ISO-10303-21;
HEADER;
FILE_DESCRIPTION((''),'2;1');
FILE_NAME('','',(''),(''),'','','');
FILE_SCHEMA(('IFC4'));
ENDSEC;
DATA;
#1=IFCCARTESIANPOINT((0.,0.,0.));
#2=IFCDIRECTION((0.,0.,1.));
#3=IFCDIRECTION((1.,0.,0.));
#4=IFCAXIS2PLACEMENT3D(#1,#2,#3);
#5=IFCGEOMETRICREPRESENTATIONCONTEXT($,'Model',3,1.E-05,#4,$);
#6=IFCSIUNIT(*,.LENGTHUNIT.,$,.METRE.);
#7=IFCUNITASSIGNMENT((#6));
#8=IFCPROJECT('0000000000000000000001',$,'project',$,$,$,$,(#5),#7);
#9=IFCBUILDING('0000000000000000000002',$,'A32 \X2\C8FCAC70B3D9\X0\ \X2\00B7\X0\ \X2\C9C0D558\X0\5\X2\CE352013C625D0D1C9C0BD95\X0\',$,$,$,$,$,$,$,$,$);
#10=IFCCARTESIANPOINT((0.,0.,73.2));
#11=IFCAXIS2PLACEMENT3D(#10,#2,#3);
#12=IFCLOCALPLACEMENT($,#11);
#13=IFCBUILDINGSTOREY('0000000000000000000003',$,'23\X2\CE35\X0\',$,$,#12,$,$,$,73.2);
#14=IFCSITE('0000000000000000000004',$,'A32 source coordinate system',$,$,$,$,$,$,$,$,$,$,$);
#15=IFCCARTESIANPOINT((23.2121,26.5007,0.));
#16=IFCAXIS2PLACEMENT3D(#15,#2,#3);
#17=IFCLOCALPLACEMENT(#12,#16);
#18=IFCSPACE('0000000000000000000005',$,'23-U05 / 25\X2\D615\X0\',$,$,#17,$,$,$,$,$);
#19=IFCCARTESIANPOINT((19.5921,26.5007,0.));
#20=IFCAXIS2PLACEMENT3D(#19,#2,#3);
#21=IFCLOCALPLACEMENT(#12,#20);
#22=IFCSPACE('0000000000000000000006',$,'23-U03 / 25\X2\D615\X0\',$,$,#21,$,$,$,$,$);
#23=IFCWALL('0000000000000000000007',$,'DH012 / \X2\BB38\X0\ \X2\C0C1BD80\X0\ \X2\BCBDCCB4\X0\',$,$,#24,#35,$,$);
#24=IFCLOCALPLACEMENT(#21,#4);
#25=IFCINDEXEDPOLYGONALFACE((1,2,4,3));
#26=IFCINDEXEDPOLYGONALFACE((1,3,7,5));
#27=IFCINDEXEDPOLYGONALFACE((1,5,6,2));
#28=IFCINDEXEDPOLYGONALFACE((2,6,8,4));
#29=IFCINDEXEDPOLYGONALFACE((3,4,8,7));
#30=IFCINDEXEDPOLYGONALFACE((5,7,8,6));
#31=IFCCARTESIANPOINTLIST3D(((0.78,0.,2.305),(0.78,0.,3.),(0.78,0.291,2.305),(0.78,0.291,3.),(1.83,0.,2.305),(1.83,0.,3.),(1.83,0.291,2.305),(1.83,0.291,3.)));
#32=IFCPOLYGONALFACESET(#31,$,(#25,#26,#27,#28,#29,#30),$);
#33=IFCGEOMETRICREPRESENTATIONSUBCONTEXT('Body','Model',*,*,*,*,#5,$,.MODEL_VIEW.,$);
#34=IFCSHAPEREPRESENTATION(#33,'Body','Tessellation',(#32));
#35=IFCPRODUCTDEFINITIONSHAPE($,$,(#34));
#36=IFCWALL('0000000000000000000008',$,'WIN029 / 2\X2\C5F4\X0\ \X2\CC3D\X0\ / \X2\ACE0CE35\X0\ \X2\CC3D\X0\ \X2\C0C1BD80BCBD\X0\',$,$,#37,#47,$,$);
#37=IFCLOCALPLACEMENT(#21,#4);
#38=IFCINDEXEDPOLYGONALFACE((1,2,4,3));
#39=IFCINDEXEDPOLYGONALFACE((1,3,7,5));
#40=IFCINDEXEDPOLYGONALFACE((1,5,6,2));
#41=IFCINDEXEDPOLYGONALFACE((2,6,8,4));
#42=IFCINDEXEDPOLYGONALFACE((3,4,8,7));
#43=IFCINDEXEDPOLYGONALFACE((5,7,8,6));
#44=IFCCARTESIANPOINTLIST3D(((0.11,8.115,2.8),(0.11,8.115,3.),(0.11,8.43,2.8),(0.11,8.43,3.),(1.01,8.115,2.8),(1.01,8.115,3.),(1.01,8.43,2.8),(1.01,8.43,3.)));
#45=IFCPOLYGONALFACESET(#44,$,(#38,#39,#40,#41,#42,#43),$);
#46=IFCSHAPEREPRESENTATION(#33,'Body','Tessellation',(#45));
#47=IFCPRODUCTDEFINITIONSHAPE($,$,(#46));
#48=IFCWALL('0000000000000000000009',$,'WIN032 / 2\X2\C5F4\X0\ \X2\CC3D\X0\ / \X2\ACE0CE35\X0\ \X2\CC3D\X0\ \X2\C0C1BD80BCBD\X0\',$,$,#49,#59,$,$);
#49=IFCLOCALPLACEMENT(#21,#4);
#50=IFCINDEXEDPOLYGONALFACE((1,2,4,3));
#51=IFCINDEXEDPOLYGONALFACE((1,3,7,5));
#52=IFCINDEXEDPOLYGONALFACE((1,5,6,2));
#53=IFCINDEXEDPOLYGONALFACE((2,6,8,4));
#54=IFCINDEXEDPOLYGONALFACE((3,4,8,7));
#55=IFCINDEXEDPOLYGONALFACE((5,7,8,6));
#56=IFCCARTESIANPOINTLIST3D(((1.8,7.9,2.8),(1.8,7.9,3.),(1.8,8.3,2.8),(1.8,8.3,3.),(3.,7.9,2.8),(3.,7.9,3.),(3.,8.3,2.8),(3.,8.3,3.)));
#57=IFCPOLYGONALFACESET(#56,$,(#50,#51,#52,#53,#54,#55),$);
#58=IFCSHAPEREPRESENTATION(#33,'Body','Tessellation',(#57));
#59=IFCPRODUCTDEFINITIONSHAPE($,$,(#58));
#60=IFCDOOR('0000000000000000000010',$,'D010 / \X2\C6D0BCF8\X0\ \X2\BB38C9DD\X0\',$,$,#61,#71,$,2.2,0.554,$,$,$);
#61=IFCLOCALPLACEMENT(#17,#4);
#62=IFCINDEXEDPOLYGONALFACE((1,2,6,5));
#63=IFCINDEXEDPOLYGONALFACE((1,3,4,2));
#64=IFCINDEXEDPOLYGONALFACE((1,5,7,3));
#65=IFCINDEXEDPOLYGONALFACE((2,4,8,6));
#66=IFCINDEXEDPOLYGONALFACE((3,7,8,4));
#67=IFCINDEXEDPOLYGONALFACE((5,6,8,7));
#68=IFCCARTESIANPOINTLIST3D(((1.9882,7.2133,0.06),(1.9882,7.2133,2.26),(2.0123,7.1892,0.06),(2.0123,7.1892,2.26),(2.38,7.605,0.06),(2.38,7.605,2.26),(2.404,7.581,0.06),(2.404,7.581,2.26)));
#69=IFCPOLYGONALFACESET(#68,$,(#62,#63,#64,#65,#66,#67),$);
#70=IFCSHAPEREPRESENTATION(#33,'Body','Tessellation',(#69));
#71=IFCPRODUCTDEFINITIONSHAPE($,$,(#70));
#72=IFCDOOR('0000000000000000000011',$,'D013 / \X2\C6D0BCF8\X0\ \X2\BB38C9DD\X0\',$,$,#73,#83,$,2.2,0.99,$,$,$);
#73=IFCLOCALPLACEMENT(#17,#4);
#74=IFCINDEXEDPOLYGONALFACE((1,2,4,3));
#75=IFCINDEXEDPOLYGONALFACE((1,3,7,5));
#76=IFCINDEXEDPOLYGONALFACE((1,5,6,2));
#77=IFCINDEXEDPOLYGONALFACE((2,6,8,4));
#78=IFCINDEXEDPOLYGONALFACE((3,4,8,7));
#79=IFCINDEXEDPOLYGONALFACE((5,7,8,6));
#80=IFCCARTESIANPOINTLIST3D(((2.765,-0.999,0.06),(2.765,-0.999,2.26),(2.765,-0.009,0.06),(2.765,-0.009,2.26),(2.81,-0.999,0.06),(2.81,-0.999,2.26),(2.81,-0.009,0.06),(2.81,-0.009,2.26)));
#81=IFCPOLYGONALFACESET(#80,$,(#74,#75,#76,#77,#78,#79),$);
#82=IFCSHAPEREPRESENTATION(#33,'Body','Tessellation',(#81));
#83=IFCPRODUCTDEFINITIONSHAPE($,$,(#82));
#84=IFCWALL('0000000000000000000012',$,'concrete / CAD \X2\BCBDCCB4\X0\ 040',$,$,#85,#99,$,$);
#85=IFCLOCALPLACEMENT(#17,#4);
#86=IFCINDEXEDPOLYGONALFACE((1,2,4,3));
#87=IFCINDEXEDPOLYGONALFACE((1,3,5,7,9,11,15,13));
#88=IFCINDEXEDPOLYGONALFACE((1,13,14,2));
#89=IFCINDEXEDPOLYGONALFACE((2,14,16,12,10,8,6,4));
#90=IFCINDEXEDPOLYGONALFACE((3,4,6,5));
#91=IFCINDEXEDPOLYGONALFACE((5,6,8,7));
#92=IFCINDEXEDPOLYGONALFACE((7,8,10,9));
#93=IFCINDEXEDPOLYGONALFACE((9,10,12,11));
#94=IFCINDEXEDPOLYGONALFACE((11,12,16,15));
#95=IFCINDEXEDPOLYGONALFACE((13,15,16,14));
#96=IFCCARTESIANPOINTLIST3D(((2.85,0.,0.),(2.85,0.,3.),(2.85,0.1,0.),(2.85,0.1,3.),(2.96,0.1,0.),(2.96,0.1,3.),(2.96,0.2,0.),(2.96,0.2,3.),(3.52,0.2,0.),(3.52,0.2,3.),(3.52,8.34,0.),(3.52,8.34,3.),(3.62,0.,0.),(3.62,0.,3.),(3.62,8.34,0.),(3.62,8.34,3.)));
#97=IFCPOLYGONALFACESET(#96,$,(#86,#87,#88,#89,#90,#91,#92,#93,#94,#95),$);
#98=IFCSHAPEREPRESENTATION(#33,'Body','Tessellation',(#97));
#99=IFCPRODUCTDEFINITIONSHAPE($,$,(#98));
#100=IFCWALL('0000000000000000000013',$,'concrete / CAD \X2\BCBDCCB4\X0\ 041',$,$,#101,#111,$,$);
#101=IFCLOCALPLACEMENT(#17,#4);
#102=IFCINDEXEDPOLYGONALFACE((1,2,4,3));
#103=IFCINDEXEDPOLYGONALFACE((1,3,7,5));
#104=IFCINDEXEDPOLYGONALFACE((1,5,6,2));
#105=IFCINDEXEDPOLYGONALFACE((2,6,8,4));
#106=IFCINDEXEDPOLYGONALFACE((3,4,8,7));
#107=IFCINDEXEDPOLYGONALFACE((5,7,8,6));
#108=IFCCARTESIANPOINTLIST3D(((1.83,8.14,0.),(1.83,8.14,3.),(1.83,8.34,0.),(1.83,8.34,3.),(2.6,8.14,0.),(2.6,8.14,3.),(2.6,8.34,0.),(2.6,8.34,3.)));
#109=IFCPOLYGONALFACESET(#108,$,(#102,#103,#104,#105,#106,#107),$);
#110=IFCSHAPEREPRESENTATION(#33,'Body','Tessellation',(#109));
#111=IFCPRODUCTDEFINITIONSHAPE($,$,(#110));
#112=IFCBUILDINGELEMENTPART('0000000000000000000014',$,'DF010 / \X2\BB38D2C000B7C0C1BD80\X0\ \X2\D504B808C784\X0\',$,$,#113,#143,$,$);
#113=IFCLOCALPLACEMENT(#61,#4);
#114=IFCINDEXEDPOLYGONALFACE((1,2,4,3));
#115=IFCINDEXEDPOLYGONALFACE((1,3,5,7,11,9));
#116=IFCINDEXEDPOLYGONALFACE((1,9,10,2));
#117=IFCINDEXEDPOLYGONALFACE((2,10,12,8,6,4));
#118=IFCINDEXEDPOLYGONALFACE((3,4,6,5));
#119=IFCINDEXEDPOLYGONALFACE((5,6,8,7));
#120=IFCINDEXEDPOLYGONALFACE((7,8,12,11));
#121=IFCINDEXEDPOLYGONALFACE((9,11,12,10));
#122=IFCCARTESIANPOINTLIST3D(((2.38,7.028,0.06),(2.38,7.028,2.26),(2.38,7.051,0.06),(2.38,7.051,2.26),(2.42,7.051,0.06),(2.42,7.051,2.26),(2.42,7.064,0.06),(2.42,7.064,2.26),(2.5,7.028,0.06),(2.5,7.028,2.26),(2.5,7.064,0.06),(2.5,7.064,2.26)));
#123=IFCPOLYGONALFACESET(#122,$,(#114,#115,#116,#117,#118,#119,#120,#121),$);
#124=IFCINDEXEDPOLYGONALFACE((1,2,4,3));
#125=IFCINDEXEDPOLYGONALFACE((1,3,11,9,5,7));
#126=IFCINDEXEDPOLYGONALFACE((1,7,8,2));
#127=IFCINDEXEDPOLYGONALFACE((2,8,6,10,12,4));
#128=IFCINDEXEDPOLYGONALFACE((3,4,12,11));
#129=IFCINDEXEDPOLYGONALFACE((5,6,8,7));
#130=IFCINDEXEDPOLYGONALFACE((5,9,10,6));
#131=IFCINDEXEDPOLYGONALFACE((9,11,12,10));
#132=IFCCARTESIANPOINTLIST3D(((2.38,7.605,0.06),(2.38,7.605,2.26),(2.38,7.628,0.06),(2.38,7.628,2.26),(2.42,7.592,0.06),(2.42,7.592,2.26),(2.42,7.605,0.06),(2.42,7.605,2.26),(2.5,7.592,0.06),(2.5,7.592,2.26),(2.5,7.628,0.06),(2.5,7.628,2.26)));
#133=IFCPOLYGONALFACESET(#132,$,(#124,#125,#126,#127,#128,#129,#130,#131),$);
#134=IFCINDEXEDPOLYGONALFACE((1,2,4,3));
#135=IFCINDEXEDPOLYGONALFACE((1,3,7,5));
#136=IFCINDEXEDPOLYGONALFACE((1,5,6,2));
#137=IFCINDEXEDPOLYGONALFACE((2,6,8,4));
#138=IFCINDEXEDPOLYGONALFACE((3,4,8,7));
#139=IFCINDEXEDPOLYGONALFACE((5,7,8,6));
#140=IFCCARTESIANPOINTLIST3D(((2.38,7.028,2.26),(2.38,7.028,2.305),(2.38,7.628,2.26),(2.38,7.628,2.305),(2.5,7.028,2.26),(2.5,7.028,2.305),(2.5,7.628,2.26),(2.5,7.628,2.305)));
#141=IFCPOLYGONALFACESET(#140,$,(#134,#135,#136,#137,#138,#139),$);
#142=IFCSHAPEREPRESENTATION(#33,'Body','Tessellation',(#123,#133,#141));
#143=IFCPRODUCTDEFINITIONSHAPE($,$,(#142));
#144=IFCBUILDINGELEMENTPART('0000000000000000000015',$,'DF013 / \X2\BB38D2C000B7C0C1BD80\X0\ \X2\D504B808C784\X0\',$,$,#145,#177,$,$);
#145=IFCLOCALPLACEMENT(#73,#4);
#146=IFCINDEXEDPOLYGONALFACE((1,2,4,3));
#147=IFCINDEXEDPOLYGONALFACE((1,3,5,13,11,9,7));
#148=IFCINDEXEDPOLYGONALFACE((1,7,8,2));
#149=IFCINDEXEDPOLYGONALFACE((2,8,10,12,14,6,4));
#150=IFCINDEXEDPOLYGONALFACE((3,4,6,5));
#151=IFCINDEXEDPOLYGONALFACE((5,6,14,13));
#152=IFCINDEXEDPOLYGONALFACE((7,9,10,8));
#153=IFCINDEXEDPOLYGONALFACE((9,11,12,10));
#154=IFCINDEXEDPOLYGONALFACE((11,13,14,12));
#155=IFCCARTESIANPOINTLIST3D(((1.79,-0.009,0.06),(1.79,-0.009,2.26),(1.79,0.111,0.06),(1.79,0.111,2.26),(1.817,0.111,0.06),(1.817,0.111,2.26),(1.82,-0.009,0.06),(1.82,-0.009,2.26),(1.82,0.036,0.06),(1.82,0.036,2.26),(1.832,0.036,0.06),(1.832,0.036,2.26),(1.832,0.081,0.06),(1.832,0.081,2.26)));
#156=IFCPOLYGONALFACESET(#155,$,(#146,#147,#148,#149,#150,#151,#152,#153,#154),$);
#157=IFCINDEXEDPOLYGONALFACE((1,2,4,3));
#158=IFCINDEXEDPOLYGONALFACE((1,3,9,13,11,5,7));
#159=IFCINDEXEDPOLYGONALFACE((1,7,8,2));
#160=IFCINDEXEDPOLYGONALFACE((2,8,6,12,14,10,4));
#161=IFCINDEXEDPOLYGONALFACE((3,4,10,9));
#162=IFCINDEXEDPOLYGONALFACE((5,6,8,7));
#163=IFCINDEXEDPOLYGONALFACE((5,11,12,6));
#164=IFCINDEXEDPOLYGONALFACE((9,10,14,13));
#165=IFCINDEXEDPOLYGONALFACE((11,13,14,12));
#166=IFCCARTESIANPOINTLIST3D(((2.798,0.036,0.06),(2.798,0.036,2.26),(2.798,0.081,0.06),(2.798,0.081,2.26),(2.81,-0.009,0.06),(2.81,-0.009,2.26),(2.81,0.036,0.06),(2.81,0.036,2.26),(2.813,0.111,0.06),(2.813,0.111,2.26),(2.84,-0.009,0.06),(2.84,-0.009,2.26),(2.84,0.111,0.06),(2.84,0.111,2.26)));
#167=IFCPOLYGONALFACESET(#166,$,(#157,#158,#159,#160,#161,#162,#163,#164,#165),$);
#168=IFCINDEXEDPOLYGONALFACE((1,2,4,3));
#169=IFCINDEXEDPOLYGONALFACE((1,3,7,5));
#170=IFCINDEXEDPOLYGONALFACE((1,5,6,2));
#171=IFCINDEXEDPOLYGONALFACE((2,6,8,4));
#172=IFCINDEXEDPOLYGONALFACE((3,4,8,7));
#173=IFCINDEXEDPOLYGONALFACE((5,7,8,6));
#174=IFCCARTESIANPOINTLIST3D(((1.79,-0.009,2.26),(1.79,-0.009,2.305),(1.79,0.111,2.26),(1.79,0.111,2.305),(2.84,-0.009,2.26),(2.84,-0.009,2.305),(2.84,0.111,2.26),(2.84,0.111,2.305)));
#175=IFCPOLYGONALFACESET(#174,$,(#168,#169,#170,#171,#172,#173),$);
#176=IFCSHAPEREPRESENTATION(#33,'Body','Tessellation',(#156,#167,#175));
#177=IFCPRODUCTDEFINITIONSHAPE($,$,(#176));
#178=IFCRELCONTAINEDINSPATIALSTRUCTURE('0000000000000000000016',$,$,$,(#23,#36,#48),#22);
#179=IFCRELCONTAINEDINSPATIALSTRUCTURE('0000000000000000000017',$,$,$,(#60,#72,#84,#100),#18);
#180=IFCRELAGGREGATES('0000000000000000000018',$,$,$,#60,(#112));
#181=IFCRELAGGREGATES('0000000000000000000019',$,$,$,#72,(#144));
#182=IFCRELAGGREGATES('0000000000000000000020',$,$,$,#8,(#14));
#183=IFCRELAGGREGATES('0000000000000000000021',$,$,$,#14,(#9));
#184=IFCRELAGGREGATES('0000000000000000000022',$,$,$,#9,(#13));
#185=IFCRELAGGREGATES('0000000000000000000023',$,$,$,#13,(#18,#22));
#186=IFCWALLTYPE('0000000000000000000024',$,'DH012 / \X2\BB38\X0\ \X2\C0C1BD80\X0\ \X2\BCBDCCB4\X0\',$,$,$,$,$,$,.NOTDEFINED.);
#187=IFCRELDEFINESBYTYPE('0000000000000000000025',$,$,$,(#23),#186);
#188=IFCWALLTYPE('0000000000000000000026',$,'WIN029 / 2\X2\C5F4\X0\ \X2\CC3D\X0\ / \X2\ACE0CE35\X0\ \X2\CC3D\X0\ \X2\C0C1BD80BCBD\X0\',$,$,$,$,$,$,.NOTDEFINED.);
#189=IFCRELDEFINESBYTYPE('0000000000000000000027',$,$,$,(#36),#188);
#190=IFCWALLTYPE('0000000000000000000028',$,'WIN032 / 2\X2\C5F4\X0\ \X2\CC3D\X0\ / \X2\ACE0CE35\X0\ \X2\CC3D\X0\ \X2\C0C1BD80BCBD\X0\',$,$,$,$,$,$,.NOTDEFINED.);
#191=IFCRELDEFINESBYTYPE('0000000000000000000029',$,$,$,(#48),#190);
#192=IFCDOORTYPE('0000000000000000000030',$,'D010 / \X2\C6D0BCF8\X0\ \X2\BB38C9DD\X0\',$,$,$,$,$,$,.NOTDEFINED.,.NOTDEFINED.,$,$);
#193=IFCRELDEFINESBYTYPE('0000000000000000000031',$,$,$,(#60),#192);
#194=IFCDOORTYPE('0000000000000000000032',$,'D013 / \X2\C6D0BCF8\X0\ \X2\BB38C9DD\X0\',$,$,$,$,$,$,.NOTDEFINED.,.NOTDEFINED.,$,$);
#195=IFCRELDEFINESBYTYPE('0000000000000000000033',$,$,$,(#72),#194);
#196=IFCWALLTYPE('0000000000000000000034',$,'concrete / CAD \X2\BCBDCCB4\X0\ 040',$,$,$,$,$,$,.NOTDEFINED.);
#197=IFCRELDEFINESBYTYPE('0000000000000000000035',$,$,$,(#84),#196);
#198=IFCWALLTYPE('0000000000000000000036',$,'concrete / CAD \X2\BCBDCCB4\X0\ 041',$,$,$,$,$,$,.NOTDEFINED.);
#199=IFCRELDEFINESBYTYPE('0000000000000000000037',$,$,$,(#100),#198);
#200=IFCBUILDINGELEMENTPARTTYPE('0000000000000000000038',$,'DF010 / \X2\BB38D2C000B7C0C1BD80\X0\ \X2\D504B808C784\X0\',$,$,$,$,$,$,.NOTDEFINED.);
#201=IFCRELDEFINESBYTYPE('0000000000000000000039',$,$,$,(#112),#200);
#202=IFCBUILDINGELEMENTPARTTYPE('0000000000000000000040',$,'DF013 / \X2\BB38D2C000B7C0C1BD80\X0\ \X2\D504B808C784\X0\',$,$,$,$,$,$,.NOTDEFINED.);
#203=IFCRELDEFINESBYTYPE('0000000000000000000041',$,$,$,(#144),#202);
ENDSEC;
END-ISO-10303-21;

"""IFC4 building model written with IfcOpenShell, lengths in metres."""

from ifc_helpers import new_model, si_unit, frame, origin, origin_with_axes, place, context, subcontext, project, spatial, polyline, outline, extrude, source, transform, mapped, type_object, type_shapes, element, aggregate, save


model = new_model("IFC4")

# Units and contexts
model_context = context("Model", 3, precision=1e-05, world=origin_with_axes())
body_context = subcontext(model_context, "Body", "Model", "MODEL_VIEW")
ifc_project = project(units=[si_unit("LENGTHUNIT", "METRE")], contexts=[model_context])

# Site, building, storey, space
storey_placement = place(None, frame((0.0, 0.0, 73.2), z_axis=(0.0, 0.0, 1.0), x_axis=(1.0, 0.0, 0.0)))
space_1_placement = place(storey_placement, frame((23.2121, 26.5007, 0.0), z_axis=(0.0, 0.0, 1.0), x_axis=(1.0, 0.0, 0.0)))
site = spatial("IfcSite", under=ifc_project, Name="A32 source coordinate system")
building = spatial("IfcBuilding", under=site, Name="A32 주거동 · 지하5층–옥탑지붕")
storey = spatial("IfcBuildingStorey", under=building, at=storey_placement, Name="23층", Elevation=73.2)
space_1 = spatial("IfcSpace", under=storey, at=space_1_placement, Name="23-U05 / 25형")

# Shared definitions
space_2_placement = place(storey_placement, frame((19.5921, 26.5007, 0.0), z_axis=(0.0, 0.0, 1.0), x_axis=(1.0, 0.0, 0.0)))
space_2 = spatial("IfcSpace", under=storey, at=space_2_placement, Name="23-U03 / 25형")

# Walls
wall_type_1 = type_object("IfcWallType", Name="DH012 / 문 상부 벽체", PredefinedType="NOTDEFINED")
shared_shape_1 = source(origin(), body_context, "Body", "SweptSolid", [
    extrude(outline(polyline([(0.78, 0.0), (0.78, 0.291), (1.83, 0.291), (1.83, 0.0), (0.78, 0.0)])), frame((0.0, 0.0, 2.305)), (0.0, 0.0, 1.0), 0.695),
])
type_shapes(wall_type_1, [shared_shape_1])
wall_1_placement = place(space_2_placement, origin_with_axes())
element("IfcWall", 1, at=wall_1_placement, inside=space_2, type_object=wall_type_1, Name="DH012 / 문 상부 벽체", context=body_context, shape_type="MappedRepresentation", body=[
    mapped(shared_shape_1, transform((0.0, 0.0, 0.0), scale=1.0)),
])
wall_type_2 = type_object("IfcWallType", Name="WIN029 / 2열 창 / 고층 창 상부벽", PredefinedType="NOTDEFINED")
shared_shape_2 = source(origin(), body_context, "Body", "SweptSolid", [
    extrude(outline(polyline([(1.01, 8.115), (1.01, 8.43), (0.11, 8.43), (0.11, 8.115), (1.01, 8.115)])), frame((0.0, 0.0, 2.8)), (0.0, 0.0, 1.0), 0.2),
])
type_shapes(wall_type_2, [shared_shape_2])
wall_2_placement = place(space_2_placement, origin_with_axes())
element("IfcWall", 2, at=wall_2_placement, inside=space_2, type_object=wall_type_2, Name="WIN029 / 2열 창 / 고층 창 상부벽", context=body_context, shape_type="MappedRepresentation", body=[
    mapped(shared_shape_2, transform((0.0, 0.0, 0.0), scale=1.0)),
])
wall_type_3 = type_object("IfcWallType", Name="WIN032 / 2열 창 / 고층 창 상부벽", PredefinedType="NOTDEFINED")
shared_shape_3 = source(origin(), body_context, "Body", "SweptSolid", [
    extrude(outline(polyline([(3.0, 7.9), (3.0, 8.3), (1.8, 8.3), (1.8, 7.9), (3.0, 7.9)])), frame((0.0, 0.0, 2.8)), (0.0, 0.0, 1.0), 0.2),
])
type_shapes(wall_type_3, [shared_shape_3])
wall_3_placement = place(space_2_placement, origin_with_axes())
element("IfcWall", 3, at=wall_3_placement, inside=space_2, type_object=wall_type_3, Name="WIN032 / 2열 창 / 고층 창 상부벽", context=body_context, shape_type="MappedRepresentation", body=[
    mapped(shared_shape_3, transform((0.0, 0.0, 0.0), scale=1.0)),
])

# Doors
door_type_1 = type_object("IfcDoorType", Name="D010 / 원본 문짝", OperationType="NOTDEFINED", PredefinedType="NOTDEFINED")
shared_shape_4 = source(origin(), body_context, "Body", "SweptSolid", [
    extrude(outline(polyline([(2.0123, 7.1892), (1.9882, 7.2133), (2.38, 7.605), (2.404, 7.581), (2.0123, 7.1892)])), frame((0.0, 0.0, 0.06)), (0.0, 0.0, 1.0), 2.2),
])
type_shapes(door_type_1, [shared_shape_4])
door_1_placement = place(space_1_placement, origin_with_axes())
door_1 = element("IfcDoor", 4, at=door_1_placement, inside=space_1, type_object=door_type_1, Name="D010 / 원본 문짝", OverallHeight=2.2, OverallWidth=0.554, context=body_context, shape_type="MappedRepresentation", body=[
    mapped(shared_shape_4, transform((0.0, 0.0, 0.0), scale=1.0)),
])
door_type_2 = type_object("IfcDoorType", Name="D013 / 원본 문짝", OperationType="NOTDEFINED", PredefinedType="NOTDEFINED")
shared_shape_5 = source(origin(), body_context, "Body", "SweptSolid", [
    extrude(outline(polyline([(2.81, -0.009), (2.81, -0.999), (2.765, -0.999), (2.765, -0.009), (2.81, -0.009)])), frame((0.0, 0.0, 0.06)), (0.0, 0.0, 1.0), 2.2),
])
type_shapes(door_type_2, [shared_shape_5])
door_2_placement = place(space_1_placement, origin_with_axes())
door_2 = element("IfcDoor", 5, at=door_2_placement, inside=space_1, type_object=door_type_2, Name="D013 / 원본 문짝", OverallHeight=2.2, OverallWidth=0.99, context=body_context, shape_type="MappedRepresentation", body=[
    mapped(shared_shape_5, transform((0.0, 0.0, 0.0), scale=1.0)),
])

# Walls
wall_type_4 = type_object("IfcWallType", Name="concrete / CAD 벽체 040", PredefinedType="NOTDEFINED")
shared_shape_6 = source(origin(), body_context, "Body", "SweptSolid", [
    extrude(outline(polyline([(3.62, 8.34), (3.62, 0.0), (2.85, 0.0), (2.85, 0.1), (2.96, 0.1), (2.96, 0.2), (3.52, 0.2), (3.52, 8.34), (3.62, 8.34)])), origin(), (0.0, 0.0, 1.0), 3.0),
])
type_shapes(wall_type_4, [shared_shape_6])
wall_4_placement = place(space_1_placement, origin_with_axes())
element("IfcWall", 6, at=wall_4_placement, inside=space_1, type_object=wall_type_4, Name="concrete / CAD 벽체 040", context=body_context, shape_type="MappedRepresentation", body=[
    mapped(shared_shape_6, transform((0.0, 0.0, 0.0), scale=1.0)),
])
wall_type_5 = type_object("IfcWallType", Name="concrete / CAD 벽체 041", PredefinedType="NOTDEFINED")
shared_shape_7 = source(origin(), body_context, "Body", "SweptSolid", [
    extrude(outline(polyline([(2.6, 8.14), (1.83, 8.14), (1.83, 8.34), (2.6, 8.34), (2.6, 8.14)])), origin(), (0.0, 0.0, 1.0), 3.0),
])
type_shapes(wall_type_5, [shared_shape_7])
wall_5_placement = place(space_1_placement, origin_with_axes())
element("IfcWall", 7, at=wall_5_placement, inside=space_1, type_object=wall_type_5, Name="concrete / CAD 벽체 041", context=body_context, shape_type="MappedRepresentation", body=[
    mapped(shared_shape_7, transform((0.0, 0.0, 0.0), scale=1.0)),
])

# Building element parts
building_element_part_type_1 = type_object("IfcBuildingElementPartType", Name="DF010 / 문틀·상부 프레임", PredefinedType="NOTDEFINED")
shared_shape_8 = source(origin(), body_context, "Body", "SweptSolid", [
    extrude(outline(polyline([(2.38, 7.028), (2.38, 7.051), (2.42, 7.051), (2.42, 7.064), (2.5, 7.064), (2.5, 7.028), (2.38, 7.028)])), frame((0.0, 0.0, 0.06)), (0.0, 0.0, 1.0), 2.2),
    extrude(outline(polyline([(2.5, 7.592), (2.42, 7.592), (2.42, 7.605), (2.38, 7.605), (2.38, 7.628), (2.5, 7.628), (2.5, 7.592)])), frame((0.0, 0.0, 0.06)), (0.0, 0.0, 1.0), 2.2),
    extrude(outline(polyline([(2.38, 7.028), (2.38, 7.628), (2.5, 7.628), (2.5, 7.028), (2.38, 7.028)])), frame((0.0, 0.0, 2.26)), (0.0, 0.0, 1.0), 0.045),
])
type_shapes(building_element_part_type_1, [shared_shape_8])
building_element_part_1_placement = place(door_1_placement, origin_with_axes())
building_element_part_1 = element("IfcBuildingElementPart", 8, at=building_element_part_1_placement, type_object=building_element_part_type_1, Name="DF010 / 문틀·상부 프레임", context=body_context, shape_type="MappedRepresentation", body=[
    mapped(shared_shape_8, transform((0.0, 0.0, 0.0), scale=1.0)),
])
aggregate(door_1, [building_element_part_1])
building_element_part_type_2 = type_object("IfcBuildingElementPartType", Name="DF013 / 문틀·상부 프레임", PredefinedType="NOTDEFINED")
shared_shape_9 = source(origin(), body_context, "Body", "SweptSolid", [
    extrude(outline(polyline([(1.79, 0.111), (1.817, 0.111), (1.832, 0.081), (1.832, 0.036), (1.82, 0.036), (1.82, -0.009), (1.79, -0.009), (1.79, 0.111)])), frame((0.0, 0.0, 0.06)), (0.0, 0.0, 1.0), 2.2),
    extrude(outline(polyline([(2.81, -0.009), (2.81, 0.036), (2.798, 0.036), (2.798, 0.081), (2.813, 0.111), (2.84, 0.111), (2.84, -0.009), (2.81, -0.009)])), frame((0.0, 0.0, 0.06)), (0.0, 0.0, 1.0), 2.2),
    extrude(outline(polyline([(1.79, -0.009), (1.79, 0.111), (2.84, 0.111), (2.84, -0.009), (1.79, -0.009)])), frame((0.0, 0.0, 2.26)), (0.0, 0.0, 1.0), 0.045),
])
type_shapes(building_element_part_type_2, [shared_shape_9])
building_element_part_2_placement = place(door_2_placement, origin_with_axes())
building_element_part_2 = element("IfcBuildingElementPart", 9, at=building_element_part_2_placement, type_object=building_element_part_type_2, Name="DF013 / 문틀·상부 프레임", context=body_context, shape_type="MappedRepresentation", body=[
    mapped(shared_shape_9, transform((0.0, 0.0, 0.0), scale=1.0)),
])
aggregate(door_2, [building_element_part_2])

save(model, "model.ifc")
